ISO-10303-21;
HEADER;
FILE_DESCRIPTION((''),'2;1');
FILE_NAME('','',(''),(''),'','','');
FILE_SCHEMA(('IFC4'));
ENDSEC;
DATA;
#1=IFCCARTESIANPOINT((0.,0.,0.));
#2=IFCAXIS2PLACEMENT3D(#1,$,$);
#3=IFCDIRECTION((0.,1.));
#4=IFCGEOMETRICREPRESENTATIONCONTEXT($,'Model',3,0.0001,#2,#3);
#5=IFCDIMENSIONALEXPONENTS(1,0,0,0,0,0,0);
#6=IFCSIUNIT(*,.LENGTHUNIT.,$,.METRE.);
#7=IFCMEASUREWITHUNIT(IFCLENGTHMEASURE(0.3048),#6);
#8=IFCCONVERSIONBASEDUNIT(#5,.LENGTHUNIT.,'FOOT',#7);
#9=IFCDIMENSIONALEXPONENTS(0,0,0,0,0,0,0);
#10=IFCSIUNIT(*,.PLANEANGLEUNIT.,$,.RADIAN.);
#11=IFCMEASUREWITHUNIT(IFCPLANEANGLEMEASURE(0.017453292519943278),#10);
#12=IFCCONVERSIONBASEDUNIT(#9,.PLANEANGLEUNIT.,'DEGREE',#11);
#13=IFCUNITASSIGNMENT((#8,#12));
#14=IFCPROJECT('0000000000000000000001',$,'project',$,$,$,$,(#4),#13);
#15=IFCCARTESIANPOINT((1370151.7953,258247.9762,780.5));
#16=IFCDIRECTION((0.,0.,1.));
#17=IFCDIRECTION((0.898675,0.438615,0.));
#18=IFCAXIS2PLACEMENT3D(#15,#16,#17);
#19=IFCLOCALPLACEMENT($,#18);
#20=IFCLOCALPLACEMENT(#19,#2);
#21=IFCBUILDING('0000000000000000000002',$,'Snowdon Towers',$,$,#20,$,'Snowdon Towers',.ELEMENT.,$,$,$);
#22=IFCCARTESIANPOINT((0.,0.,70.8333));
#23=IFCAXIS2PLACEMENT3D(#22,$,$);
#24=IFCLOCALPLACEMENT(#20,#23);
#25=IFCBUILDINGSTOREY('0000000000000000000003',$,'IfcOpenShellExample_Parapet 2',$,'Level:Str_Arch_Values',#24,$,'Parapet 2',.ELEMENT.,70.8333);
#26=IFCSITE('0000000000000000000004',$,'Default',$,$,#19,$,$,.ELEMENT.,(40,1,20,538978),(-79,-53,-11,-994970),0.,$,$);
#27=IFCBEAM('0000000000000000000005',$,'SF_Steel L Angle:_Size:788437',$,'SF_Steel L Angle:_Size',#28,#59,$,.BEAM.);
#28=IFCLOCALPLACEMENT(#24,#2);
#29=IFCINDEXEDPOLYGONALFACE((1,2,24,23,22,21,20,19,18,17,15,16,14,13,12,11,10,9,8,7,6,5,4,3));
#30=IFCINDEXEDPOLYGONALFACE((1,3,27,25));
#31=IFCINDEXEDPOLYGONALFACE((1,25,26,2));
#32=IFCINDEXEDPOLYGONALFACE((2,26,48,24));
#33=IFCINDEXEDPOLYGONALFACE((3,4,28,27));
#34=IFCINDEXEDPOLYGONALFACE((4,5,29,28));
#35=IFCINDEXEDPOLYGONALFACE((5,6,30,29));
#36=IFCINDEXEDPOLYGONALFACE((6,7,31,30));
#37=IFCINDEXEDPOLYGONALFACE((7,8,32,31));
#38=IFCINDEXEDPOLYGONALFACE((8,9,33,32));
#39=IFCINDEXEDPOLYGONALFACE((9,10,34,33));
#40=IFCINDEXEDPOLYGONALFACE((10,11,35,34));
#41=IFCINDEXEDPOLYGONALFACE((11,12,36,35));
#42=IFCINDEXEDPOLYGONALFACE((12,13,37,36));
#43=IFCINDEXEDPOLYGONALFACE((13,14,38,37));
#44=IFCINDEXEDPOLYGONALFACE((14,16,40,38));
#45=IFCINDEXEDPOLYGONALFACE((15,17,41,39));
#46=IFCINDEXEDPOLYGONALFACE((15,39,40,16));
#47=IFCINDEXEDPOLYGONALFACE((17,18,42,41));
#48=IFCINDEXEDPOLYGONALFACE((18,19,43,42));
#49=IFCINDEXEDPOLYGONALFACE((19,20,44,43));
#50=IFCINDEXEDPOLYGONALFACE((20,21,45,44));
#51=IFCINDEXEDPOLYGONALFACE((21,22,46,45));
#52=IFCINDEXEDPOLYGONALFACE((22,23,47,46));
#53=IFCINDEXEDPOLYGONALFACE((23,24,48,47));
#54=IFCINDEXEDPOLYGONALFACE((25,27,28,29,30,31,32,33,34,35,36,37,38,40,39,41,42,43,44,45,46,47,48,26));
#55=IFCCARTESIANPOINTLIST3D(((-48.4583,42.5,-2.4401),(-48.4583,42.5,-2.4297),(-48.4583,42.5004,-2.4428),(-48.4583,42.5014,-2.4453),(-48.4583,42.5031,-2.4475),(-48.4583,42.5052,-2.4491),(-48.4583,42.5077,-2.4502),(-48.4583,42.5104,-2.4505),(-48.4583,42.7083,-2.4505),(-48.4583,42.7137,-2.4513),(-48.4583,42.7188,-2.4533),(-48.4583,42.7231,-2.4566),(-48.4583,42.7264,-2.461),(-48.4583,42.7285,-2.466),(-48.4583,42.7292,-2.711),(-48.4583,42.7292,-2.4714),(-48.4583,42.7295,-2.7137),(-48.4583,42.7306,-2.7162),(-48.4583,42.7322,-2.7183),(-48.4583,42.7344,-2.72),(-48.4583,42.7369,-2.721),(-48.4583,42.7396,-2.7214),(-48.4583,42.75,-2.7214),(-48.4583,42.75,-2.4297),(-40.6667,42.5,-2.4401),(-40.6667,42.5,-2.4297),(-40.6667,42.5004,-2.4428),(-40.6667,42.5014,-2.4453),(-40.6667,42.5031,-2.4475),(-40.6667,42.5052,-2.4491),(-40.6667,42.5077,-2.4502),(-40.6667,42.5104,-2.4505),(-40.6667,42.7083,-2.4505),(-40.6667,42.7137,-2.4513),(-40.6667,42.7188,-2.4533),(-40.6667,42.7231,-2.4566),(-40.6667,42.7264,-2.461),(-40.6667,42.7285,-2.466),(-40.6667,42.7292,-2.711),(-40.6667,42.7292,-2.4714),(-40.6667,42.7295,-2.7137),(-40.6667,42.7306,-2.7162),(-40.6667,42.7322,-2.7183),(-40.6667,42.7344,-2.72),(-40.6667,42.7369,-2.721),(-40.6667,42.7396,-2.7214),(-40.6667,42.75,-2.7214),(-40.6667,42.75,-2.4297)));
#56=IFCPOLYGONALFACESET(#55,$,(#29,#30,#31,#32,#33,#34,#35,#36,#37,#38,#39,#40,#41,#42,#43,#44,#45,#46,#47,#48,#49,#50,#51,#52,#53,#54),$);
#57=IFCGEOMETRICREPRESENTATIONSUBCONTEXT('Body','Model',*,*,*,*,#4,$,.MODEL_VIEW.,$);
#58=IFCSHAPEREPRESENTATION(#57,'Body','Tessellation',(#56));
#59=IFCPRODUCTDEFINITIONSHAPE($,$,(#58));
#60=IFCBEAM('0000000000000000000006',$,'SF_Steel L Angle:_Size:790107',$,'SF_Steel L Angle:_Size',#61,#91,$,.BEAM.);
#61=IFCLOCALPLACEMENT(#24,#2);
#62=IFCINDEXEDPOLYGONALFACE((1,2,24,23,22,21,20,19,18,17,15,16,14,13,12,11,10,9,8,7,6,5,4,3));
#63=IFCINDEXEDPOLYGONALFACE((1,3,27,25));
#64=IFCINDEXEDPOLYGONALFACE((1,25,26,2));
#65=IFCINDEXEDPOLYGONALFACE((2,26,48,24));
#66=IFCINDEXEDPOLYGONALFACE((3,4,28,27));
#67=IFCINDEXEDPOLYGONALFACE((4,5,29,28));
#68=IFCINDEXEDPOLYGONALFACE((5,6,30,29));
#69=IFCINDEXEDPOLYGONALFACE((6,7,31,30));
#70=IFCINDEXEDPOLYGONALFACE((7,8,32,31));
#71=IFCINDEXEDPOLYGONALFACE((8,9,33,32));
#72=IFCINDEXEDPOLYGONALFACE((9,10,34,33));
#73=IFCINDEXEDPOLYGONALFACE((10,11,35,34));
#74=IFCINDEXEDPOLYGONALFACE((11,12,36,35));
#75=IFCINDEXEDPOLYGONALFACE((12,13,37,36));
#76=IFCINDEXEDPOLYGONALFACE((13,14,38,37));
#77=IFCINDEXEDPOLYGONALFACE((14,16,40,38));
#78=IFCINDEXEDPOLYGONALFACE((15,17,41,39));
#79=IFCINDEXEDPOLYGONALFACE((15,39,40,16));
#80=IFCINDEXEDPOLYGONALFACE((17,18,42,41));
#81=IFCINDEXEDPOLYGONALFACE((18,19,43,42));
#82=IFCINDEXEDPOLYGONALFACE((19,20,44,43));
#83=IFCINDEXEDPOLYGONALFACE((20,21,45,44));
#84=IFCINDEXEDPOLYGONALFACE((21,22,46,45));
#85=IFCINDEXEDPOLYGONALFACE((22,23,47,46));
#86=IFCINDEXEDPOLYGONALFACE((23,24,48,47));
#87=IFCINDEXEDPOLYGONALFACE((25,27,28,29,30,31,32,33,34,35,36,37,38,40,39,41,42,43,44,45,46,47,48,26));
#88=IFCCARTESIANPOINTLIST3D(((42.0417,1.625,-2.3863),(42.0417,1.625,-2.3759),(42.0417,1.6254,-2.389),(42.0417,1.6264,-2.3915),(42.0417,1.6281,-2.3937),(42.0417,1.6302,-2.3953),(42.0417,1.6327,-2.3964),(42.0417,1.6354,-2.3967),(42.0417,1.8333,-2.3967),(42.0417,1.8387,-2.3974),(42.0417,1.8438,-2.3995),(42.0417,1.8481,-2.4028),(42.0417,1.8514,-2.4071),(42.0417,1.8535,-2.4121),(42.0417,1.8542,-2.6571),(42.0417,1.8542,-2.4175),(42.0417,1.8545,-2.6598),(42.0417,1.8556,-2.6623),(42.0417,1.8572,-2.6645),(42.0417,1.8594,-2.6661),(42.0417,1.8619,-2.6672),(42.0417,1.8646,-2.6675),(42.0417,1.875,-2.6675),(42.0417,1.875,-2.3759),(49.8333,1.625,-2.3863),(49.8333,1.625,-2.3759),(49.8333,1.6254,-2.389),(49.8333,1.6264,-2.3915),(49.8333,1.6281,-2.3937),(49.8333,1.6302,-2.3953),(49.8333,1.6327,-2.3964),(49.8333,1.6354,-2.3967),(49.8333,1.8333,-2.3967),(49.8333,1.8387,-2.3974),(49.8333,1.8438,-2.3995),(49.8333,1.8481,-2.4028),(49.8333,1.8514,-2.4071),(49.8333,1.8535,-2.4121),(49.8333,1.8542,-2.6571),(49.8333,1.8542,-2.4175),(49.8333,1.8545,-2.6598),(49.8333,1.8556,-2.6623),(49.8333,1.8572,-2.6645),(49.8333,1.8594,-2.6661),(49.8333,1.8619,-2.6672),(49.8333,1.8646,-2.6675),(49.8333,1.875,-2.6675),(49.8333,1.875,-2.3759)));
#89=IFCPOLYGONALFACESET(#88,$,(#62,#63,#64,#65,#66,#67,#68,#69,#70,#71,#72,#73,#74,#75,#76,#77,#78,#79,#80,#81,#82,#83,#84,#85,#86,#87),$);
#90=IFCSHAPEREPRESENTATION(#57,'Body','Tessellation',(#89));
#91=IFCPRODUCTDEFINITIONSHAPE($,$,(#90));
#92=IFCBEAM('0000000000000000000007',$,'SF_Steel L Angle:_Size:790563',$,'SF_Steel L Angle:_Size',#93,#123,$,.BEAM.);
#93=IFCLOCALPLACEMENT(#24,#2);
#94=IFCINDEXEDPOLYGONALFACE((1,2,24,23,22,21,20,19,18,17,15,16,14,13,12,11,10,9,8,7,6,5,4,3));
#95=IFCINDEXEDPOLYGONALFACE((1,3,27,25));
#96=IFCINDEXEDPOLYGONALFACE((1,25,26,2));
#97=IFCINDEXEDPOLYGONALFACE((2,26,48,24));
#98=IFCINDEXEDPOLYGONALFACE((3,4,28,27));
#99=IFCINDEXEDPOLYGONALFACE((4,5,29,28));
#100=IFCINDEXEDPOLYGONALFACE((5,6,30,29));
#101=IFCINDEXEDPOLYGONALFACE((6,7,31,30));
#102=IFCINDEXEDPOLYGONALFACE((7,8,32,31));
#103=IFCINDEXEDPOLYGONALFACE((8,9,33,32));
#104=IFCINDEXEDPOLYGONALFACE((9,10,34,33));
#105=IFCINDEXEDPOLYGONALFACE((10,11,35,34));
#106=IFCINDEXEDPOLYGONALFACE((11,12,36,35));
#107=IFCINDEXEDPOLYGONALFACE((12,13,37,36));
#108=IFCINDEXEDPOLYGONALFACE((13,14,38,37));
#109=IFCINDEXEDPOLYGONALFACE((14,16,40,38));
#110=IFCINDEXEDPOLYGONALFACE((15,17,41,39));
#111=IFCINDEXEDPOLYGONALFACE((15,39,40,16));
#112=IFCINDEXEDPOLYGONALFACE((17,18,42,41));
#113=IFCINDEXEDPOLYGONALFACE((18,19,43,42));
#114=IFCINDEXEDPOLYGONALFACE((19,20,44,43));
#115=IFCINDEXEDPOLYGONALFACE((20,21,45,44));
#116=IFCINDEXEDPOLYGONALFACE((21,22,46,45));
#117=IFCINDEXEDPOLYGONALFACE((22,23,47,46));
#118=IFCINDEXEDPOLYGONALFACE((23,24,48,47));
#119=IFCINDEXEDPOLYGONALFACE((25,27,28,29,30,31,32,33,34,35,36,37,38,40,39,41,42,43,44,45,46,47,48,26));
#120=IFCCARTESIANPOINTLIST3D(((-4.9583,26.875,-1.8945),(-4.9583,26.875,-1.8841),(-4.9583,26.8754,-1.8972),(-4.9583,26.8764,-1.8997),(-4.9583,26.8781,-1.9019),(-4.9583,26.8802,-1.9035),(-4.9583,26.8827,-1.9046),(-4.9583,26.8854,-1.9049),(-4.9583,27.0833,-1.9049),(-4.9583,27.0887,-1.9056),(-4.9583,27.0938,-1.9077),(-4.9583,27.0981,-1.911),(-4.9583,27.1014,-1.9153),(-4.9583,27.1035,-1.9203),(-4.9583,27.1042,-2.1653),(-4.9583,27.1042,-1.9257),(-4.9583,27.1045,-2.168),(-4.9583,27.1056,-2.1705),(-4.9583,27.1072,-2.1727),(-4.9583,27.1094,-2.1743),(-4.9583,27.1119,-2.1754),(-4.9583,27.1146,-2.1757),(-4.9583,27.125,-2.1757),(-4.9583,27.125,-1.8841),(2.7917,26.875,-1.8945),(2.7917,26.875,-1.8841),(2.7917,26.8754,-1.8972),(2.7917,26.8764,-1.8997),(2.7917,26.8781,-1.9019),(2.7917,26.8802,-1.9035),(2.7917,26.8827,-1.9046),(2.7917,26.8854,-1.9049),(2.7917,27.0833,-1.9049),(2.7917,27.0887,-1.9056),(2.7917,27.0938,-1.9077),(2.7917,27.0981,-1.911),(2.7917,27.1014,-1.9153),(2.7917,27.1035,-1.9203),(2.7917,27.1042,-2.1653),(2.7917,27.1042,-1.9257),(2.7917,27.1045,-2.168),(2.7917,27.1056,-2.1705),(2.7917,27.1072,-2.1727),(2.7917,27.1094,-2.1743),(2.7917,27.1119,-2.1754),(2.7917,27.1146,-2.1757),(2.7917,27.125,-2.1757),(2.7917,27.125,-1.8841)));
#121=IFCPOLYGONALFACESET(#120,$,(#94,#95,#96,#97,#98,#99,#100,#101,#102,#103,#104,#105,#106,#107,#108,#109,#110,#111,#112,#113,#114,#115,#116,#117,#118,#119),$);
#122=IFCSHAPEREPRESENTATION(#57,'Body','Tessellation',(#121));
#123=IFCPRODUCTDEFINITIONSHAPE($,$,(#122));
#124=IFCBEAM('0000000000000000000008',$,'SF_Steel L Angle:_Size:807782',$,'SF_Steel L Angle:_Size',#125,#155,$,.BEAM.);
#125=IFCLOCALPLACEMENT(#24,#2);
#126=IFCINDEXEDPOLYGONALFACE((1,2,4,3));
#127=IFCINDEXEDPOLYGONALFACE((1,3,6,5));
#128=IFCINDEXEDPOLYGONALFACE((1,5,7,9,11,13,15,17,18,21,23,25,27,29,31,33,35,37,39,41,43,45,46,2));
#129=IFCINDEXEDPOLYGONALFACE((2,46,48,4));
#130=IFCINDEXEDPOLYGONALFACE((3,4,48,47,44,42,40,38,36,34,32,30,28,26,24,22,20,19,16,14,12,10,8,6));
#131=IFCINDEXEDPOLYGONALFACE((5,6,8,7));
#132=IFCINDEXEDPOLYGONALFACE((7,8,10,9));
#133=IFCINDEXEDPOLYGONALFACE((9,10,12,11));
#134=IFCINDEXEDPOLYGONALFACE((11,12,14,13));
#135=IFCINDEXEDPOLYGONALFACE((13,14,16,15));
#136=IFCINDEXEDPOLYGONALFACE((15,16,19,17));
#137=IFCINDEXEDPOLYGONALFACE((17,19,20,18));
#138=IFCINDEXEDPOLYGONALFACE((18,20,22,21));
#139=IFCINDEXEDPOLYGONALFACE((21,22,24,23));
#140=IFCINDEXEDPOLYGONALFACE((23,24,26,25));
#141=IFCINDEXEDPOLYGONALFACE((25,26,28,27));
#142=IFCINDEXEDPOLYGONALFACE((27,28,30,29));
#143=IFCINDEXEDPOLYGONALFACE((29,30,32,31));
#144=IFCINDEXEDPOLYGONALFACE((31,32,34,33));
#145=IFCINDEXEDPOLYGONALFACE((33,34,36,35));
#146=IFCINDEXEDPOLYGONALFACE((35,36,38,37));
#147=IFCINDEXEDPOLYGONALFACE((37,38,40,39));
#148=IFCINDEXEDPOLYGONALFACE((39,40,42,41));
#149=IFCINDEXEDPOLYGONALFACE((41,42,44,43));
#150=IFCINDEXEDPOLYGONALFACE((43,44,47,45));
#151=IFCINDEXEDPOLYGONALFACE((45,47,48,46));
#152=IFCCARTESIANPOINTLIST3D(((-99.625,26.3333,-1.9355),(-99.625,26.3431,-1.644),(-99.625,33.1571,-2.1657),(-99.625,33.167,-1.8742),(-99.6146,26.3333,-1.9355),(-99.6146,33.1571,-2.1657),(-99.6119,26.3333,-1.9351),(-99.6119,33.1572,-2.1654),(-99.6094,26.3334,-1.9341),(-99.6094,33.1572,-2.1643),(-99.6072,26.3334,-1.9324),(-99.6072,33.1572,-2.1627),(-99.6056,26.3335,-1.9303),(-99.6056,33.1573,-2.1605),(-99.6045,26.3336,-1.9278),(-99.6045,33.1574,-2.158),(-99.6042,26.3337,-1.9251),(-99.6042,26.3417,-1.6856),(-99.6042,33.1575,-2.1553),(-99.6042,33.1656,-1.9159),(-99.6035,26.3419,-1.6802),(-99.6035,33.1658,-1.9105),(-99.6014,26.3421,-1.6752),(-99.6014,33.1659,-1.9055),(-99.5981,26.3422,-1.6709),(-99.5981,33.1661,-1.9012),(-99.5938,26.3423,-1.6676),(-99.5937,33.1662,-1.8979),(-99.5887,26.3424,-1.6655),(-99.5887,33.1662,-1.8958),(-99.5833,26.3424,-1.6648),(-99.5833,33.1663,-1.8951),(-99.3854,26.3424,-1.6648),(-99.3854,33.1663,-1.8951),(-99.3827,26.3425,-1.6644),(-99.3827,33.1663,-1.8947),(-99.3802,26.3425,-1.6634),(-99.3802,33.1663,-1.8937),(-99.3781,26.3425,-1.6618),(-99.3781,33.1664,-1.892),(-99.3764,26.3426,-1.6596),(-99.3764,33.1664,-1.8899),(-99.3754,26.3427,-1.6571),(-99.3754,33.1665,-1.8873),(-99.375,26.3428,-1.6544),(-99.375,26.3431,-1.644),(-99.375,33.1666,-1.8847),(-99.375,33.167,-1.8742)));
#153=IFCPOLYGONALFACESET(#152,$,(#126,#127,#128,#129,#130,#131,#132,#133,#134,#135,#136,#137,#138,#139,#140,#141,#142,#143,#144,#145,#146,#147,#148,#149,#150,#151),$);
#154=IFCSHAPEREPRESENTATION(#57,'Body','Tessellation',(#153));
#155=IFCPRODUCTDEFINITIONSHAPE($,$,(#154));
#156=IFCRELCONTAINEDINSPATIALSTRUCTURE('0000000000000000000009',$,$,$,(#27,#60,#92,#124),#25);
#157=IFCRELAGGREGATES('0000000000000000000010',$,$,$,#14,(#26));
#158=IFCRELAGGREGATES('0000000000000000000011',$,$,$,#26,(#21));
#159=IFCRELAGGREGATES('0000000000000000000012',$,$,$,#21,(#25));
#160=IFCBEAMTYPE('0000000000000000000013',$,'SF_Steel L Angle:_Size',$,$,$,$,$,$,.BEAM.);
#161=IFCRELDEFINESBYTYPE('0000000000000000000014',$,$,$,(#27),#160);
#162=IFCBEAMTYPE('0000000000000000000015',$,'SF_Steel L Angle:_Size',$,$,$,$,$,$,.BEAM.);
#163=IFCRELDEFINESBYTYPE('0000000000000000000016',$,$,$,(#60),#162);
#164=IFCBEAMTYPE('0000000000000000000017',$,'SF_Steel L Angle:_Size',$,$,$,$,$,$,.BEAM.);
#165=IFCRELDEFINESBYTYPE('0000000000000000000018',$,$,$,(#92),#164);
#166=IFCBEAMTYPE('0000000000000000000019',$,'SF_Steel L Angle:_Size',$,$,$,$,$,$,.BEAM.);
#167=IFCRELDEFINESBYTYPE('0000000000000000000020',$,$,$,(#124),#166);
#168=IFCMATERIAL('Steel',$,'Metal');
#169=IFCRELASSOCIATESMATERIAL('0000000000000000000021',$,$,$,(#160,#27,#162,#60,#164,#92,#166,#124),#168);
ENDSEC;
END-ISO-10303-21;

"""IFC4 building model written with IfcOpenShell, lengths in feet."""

from ifc_helpers import new_model, entity, si_unit, converted_unit, direction, frame, origin, place, context, subcontext, project, spatial, line, arc, indexed_curve, outline, extrude, source, transform, mapped, material, type_object, type_shapes, element, save


model = new_model("IFC4")

# Units and contexts
model_context = context("Model", 3, precision=0.0001, world=origin(), true_north=direction((0.0, 1.0)))
body_context = subcontext(model_context, "Body", "Model", "MODEL_VIEW")
ifc_project = project(units=[converted_unit("LENGTHUNIT", "FOOT", entity("IfcLengthMeasure", 0.3048), si_unit("LENGTHUNIT", "METRE"), dimensions=[1, 0, 0, 0, 0, 0, 0]), converted_unit("PLANEANGLEUNIT", "DEGREE", entity("IfcPlaneAngleMeasure", 0.017453292519943278), si_unit("PLANEANGLEUNIT", "RADIAN"), dimensions=[0, 0, 0, 0, 0, 0, 0])], contexts=[model_context])

# Site, building, storey
site_placement = place(None, frame((1370151.7953, 258247.9762, 780.5), z_axis=(0.0, 0.0, 1.0), x_axis=(0.898675, 0.438615, 0.0)))
site = spatial("IfcSite", under=ifc_project, at=site_placement, Name="Default", CompositionType="ELEMENT", RefLatitude=(40, 1, 20, 538978), RefLongitude=(-79, -53, -11, -994970), RefElevation=0.0)
building_placement = place(site_placement, origin())
building = spatial("IfcBuilding", under=site, at=building_placement, Name="Snowdon Towers", LongName="Snowdon Towers", CompositionType="ELEMENT")
storey_placement = place(building_placement, frame((0.0, 0.0, 70.8333)))
storey = spatial("IfcBuildingStorey", under=building, at=storey_placement, Name="IfcOpenShellExample_Parapet 2", ObjectType="Level:Str_Arch_Values", LongName="Parapet 2", CompositionType="ELEMENT", Elevation=70.8333)

# Beams
ifc_material_1 = material(Name="Steel", Category="Metal")
beam_type_1 = type_object("IfcBeamType", Name="SF_Steel L Angle:_Size", PredefinedType="BEAM", material=ifc_material_1)
shared_shape_1 = source(origin(), body_context, "Body", "SweptSolid", [
    extrude(outline(indexed_curve([(-0.0926, -0.1065), (0.1574, -0.1065), (0.1574, -0.0961), (0.1544, -0.0887), (0.147, -0.0856), (-0.0509, -0.0856), (-0.0657, -0.0795), (-0.0718, -0.0648), (-0.0718, 0.1748), (-0.0748, 0.1821), (-0.0822, 0.1852), (-0.0926, 0.1852)], segments=[line(1, 2, 3), arc(3, 4, 5), line(5, 6), arc(6, 7, 8), line(8, 9), arc(9, 10, 11), line(11, 12, 1)], self_intersect=False)), frame((-3.8958, -0.0926, -0.1065), z_axis=(1.0, 0.0, 0.0), x_axis=(0.0, -1.0, 0.0)), (0.0, 0.0, 1.0), 7.7917),
])
type_shapes(beam_type_1, [shared_shape_1])
beam_1_placement = place(storey_placement, frame((-44.5625, 42.75, -2.4297)))
element("IfcBeam", 1, at=beam_1_placement, inside=storey, type_object=beam_type_1, material=ifc_material_1, Name="SF_Steel L Angle:_Size:788437", ObjectType="SF_Steel L Angle:_Size", PredefinedType="BEAM", context=body_context, shape_type="MappedRepresentation", body=[
    mapped(shared_shape_1, transform((0.0, 0.0, 0.0), scale=1.0)),
])
beam_type_2 = type_object("IfcBeamType", Name="SF_Steel L Angle:_Size", PredefinedType="BEAM", material=ifc_material_1)
shared_shape_2 = source(origin(), body_context, "Body", "SweptSolid", [
    extrude(outline(indexed_curve([(-0.0926, -0.1065), (0.1574, -0.1065), (0.1574, -0.0961), (0.1544, -0.0887), (0.147, -0.0856), (-0.0509, -0.0856), (-0.0657, -0.0795), (-0.0718, -0.0648), (-0.0718, 0.1748), (-0.0748, 0.1821), (-0.0822, 0.1852), (-0.0926, 0.1852)], segments=[line(1, 2, 3), arc(3, 4, 5), line(5, 6), arc(6, 7, 8), line(8, 9), arc(9, 10, 11), line(11, 12, 1)], self_intersect=False)), frame((-3.8958, -0.0926, -0.1065), z_axis=(1.0, 0.0, 0.0), x_axis=(0.0, -1.0, 0.0)), (0.0, 0.0, 1.0), 7.7917),
])
type_shapes(beam_type_2, [shared_shape_2])
beam_2_placement = place(storey_placement, frame((45.9375, 1.875, -2.3759)))
element("IfcBeam", 2, at=beam_2_placement, inside=storey, type_object=beam_type_2, material=ifc_material_1, Name="SF_Steel L Angle:_Size:790107", ObjectType="SF_Steel L Angle:_Size", PredefinedType="BEAM", context=body_context, shape_type="MappedRepresentation", body=[
    mapped(shared_shape_2, transform((0.0, 0.0, 0.0), scale=1.0)),
])
beam_type_3 = type_object("IfcBeamType", Name="SF_Steel L Angle:_Size", PredefinedType="BEAM", material=ifc_material_1)
shared_shape_3 = source(origin(), body_context, "Body", "SweptSolid", [
    extrude(outline(indexed_curve([(-0.0926, -0.1065), (0.1574, -0.1065), (0.1574, -0.0961), (0.1544, -0.0887), (0.147, -0.0856), (-0.0509, -0.0856), (-0.0657, -0.0795), (-0.0718, -0.0648), (-0.0718, 0.1748), (-0.0748, 0.1821), (-0.0822, 0.1852), (-0.0926, 0.1852)], segments=[line(1, 2, 3), arc(3, 4, 5), line(5, 6), arc(6, 7, 8), line(8, 9), arc(9, 10, 11), line(11, 12, 1)], self_intersect=False)), frame((-3.875, -0.0926, -0.1065), z_axis=(1.0, 0.0, 0.0), x_axis=(0.0, -1.0, 0.0)), (0.0, 0.0, 1.0), 7.75),
])
type_shapes(beam_type_3, [shared_shape_3])
beam_3_placement = place(storey_placement, frame((-1.0833, 27.125, -1.8841)))
element("IfcBeam", 3, at=beam_3_placement, inside=storey, type_object=beam_type_3, material=ifc_material_1, Name="SF_Steel L Angle:_Size:790563", ObjectType="SF_Steel L Angle:_Size", PredefinedType="BEAM", context=body_context, shape_type="MappedRepresentation", body=[
    mapped(shared_shape_3, transform((0.0, 0.0, 0.0), scale=1.0)),
])
beam_type_4 = type_object("IfcBeamType", Name="SF_Steel L Angle:_Size", PredefinedType="BEAM", material=ifc_material_1)
shared_shape_4 = source(origin(), body_context, "Body", "SweptSolid", [
    extrude(outline(indexed_curve([(-0.0926, -0.1065), (0.1574, -0.1065), (0.1574, -0.0961), (0.1544, -0.0887), (0.147, -0.0856), (-0.0509, -0.0856), (-0.0657, -0.0795), (-0.0718, -0.0648), (-0.0718, 0.1748), (-0.0748, 0.1821), (-0.0822, 0.1852), (-0.0926, 0.1852)], segments=[line(1, 2, 3), arc(3, 4, 5), line(5, 6), arc(6, 7, 8), line(8, 9), arc(9, 10, 11), line(11, 12, 1)], self_intersect=False)), frame((-3.4088, -0.0926, -0.1065), z_axis=(1.0, 0.0, 0.0), x_axis=(0.0, -1.0, 0.0)), (0.0, 0.0, 1.0), 6.8277),
])
type_shapes(beam_type_4, [shared_shape_4])
beam_4_placement = place(storey_placement, frame((-99.625, 29.75, -1.7589), z_axis=(0.0, 0.033724, 0.999431), x_axis=(0.0, 0.999431, -0.033724)))
element("IfcBeam", 4, at=beam_4_placement, inside=storey, type_object=beam_type_4, material=ifc_material_1, Name="SF_Steel L Angle:_Size:807782", ObjectType="SF_Steel L Angle:_Size", PredefinedType="BEAM", context=body_context, shape_type="MappedRepresentation", body=[
    mapped(shared_shape_4, transform((0.0, 0.0, 0.0), scale=1.0)),
])

save(model, "model.ifc")
